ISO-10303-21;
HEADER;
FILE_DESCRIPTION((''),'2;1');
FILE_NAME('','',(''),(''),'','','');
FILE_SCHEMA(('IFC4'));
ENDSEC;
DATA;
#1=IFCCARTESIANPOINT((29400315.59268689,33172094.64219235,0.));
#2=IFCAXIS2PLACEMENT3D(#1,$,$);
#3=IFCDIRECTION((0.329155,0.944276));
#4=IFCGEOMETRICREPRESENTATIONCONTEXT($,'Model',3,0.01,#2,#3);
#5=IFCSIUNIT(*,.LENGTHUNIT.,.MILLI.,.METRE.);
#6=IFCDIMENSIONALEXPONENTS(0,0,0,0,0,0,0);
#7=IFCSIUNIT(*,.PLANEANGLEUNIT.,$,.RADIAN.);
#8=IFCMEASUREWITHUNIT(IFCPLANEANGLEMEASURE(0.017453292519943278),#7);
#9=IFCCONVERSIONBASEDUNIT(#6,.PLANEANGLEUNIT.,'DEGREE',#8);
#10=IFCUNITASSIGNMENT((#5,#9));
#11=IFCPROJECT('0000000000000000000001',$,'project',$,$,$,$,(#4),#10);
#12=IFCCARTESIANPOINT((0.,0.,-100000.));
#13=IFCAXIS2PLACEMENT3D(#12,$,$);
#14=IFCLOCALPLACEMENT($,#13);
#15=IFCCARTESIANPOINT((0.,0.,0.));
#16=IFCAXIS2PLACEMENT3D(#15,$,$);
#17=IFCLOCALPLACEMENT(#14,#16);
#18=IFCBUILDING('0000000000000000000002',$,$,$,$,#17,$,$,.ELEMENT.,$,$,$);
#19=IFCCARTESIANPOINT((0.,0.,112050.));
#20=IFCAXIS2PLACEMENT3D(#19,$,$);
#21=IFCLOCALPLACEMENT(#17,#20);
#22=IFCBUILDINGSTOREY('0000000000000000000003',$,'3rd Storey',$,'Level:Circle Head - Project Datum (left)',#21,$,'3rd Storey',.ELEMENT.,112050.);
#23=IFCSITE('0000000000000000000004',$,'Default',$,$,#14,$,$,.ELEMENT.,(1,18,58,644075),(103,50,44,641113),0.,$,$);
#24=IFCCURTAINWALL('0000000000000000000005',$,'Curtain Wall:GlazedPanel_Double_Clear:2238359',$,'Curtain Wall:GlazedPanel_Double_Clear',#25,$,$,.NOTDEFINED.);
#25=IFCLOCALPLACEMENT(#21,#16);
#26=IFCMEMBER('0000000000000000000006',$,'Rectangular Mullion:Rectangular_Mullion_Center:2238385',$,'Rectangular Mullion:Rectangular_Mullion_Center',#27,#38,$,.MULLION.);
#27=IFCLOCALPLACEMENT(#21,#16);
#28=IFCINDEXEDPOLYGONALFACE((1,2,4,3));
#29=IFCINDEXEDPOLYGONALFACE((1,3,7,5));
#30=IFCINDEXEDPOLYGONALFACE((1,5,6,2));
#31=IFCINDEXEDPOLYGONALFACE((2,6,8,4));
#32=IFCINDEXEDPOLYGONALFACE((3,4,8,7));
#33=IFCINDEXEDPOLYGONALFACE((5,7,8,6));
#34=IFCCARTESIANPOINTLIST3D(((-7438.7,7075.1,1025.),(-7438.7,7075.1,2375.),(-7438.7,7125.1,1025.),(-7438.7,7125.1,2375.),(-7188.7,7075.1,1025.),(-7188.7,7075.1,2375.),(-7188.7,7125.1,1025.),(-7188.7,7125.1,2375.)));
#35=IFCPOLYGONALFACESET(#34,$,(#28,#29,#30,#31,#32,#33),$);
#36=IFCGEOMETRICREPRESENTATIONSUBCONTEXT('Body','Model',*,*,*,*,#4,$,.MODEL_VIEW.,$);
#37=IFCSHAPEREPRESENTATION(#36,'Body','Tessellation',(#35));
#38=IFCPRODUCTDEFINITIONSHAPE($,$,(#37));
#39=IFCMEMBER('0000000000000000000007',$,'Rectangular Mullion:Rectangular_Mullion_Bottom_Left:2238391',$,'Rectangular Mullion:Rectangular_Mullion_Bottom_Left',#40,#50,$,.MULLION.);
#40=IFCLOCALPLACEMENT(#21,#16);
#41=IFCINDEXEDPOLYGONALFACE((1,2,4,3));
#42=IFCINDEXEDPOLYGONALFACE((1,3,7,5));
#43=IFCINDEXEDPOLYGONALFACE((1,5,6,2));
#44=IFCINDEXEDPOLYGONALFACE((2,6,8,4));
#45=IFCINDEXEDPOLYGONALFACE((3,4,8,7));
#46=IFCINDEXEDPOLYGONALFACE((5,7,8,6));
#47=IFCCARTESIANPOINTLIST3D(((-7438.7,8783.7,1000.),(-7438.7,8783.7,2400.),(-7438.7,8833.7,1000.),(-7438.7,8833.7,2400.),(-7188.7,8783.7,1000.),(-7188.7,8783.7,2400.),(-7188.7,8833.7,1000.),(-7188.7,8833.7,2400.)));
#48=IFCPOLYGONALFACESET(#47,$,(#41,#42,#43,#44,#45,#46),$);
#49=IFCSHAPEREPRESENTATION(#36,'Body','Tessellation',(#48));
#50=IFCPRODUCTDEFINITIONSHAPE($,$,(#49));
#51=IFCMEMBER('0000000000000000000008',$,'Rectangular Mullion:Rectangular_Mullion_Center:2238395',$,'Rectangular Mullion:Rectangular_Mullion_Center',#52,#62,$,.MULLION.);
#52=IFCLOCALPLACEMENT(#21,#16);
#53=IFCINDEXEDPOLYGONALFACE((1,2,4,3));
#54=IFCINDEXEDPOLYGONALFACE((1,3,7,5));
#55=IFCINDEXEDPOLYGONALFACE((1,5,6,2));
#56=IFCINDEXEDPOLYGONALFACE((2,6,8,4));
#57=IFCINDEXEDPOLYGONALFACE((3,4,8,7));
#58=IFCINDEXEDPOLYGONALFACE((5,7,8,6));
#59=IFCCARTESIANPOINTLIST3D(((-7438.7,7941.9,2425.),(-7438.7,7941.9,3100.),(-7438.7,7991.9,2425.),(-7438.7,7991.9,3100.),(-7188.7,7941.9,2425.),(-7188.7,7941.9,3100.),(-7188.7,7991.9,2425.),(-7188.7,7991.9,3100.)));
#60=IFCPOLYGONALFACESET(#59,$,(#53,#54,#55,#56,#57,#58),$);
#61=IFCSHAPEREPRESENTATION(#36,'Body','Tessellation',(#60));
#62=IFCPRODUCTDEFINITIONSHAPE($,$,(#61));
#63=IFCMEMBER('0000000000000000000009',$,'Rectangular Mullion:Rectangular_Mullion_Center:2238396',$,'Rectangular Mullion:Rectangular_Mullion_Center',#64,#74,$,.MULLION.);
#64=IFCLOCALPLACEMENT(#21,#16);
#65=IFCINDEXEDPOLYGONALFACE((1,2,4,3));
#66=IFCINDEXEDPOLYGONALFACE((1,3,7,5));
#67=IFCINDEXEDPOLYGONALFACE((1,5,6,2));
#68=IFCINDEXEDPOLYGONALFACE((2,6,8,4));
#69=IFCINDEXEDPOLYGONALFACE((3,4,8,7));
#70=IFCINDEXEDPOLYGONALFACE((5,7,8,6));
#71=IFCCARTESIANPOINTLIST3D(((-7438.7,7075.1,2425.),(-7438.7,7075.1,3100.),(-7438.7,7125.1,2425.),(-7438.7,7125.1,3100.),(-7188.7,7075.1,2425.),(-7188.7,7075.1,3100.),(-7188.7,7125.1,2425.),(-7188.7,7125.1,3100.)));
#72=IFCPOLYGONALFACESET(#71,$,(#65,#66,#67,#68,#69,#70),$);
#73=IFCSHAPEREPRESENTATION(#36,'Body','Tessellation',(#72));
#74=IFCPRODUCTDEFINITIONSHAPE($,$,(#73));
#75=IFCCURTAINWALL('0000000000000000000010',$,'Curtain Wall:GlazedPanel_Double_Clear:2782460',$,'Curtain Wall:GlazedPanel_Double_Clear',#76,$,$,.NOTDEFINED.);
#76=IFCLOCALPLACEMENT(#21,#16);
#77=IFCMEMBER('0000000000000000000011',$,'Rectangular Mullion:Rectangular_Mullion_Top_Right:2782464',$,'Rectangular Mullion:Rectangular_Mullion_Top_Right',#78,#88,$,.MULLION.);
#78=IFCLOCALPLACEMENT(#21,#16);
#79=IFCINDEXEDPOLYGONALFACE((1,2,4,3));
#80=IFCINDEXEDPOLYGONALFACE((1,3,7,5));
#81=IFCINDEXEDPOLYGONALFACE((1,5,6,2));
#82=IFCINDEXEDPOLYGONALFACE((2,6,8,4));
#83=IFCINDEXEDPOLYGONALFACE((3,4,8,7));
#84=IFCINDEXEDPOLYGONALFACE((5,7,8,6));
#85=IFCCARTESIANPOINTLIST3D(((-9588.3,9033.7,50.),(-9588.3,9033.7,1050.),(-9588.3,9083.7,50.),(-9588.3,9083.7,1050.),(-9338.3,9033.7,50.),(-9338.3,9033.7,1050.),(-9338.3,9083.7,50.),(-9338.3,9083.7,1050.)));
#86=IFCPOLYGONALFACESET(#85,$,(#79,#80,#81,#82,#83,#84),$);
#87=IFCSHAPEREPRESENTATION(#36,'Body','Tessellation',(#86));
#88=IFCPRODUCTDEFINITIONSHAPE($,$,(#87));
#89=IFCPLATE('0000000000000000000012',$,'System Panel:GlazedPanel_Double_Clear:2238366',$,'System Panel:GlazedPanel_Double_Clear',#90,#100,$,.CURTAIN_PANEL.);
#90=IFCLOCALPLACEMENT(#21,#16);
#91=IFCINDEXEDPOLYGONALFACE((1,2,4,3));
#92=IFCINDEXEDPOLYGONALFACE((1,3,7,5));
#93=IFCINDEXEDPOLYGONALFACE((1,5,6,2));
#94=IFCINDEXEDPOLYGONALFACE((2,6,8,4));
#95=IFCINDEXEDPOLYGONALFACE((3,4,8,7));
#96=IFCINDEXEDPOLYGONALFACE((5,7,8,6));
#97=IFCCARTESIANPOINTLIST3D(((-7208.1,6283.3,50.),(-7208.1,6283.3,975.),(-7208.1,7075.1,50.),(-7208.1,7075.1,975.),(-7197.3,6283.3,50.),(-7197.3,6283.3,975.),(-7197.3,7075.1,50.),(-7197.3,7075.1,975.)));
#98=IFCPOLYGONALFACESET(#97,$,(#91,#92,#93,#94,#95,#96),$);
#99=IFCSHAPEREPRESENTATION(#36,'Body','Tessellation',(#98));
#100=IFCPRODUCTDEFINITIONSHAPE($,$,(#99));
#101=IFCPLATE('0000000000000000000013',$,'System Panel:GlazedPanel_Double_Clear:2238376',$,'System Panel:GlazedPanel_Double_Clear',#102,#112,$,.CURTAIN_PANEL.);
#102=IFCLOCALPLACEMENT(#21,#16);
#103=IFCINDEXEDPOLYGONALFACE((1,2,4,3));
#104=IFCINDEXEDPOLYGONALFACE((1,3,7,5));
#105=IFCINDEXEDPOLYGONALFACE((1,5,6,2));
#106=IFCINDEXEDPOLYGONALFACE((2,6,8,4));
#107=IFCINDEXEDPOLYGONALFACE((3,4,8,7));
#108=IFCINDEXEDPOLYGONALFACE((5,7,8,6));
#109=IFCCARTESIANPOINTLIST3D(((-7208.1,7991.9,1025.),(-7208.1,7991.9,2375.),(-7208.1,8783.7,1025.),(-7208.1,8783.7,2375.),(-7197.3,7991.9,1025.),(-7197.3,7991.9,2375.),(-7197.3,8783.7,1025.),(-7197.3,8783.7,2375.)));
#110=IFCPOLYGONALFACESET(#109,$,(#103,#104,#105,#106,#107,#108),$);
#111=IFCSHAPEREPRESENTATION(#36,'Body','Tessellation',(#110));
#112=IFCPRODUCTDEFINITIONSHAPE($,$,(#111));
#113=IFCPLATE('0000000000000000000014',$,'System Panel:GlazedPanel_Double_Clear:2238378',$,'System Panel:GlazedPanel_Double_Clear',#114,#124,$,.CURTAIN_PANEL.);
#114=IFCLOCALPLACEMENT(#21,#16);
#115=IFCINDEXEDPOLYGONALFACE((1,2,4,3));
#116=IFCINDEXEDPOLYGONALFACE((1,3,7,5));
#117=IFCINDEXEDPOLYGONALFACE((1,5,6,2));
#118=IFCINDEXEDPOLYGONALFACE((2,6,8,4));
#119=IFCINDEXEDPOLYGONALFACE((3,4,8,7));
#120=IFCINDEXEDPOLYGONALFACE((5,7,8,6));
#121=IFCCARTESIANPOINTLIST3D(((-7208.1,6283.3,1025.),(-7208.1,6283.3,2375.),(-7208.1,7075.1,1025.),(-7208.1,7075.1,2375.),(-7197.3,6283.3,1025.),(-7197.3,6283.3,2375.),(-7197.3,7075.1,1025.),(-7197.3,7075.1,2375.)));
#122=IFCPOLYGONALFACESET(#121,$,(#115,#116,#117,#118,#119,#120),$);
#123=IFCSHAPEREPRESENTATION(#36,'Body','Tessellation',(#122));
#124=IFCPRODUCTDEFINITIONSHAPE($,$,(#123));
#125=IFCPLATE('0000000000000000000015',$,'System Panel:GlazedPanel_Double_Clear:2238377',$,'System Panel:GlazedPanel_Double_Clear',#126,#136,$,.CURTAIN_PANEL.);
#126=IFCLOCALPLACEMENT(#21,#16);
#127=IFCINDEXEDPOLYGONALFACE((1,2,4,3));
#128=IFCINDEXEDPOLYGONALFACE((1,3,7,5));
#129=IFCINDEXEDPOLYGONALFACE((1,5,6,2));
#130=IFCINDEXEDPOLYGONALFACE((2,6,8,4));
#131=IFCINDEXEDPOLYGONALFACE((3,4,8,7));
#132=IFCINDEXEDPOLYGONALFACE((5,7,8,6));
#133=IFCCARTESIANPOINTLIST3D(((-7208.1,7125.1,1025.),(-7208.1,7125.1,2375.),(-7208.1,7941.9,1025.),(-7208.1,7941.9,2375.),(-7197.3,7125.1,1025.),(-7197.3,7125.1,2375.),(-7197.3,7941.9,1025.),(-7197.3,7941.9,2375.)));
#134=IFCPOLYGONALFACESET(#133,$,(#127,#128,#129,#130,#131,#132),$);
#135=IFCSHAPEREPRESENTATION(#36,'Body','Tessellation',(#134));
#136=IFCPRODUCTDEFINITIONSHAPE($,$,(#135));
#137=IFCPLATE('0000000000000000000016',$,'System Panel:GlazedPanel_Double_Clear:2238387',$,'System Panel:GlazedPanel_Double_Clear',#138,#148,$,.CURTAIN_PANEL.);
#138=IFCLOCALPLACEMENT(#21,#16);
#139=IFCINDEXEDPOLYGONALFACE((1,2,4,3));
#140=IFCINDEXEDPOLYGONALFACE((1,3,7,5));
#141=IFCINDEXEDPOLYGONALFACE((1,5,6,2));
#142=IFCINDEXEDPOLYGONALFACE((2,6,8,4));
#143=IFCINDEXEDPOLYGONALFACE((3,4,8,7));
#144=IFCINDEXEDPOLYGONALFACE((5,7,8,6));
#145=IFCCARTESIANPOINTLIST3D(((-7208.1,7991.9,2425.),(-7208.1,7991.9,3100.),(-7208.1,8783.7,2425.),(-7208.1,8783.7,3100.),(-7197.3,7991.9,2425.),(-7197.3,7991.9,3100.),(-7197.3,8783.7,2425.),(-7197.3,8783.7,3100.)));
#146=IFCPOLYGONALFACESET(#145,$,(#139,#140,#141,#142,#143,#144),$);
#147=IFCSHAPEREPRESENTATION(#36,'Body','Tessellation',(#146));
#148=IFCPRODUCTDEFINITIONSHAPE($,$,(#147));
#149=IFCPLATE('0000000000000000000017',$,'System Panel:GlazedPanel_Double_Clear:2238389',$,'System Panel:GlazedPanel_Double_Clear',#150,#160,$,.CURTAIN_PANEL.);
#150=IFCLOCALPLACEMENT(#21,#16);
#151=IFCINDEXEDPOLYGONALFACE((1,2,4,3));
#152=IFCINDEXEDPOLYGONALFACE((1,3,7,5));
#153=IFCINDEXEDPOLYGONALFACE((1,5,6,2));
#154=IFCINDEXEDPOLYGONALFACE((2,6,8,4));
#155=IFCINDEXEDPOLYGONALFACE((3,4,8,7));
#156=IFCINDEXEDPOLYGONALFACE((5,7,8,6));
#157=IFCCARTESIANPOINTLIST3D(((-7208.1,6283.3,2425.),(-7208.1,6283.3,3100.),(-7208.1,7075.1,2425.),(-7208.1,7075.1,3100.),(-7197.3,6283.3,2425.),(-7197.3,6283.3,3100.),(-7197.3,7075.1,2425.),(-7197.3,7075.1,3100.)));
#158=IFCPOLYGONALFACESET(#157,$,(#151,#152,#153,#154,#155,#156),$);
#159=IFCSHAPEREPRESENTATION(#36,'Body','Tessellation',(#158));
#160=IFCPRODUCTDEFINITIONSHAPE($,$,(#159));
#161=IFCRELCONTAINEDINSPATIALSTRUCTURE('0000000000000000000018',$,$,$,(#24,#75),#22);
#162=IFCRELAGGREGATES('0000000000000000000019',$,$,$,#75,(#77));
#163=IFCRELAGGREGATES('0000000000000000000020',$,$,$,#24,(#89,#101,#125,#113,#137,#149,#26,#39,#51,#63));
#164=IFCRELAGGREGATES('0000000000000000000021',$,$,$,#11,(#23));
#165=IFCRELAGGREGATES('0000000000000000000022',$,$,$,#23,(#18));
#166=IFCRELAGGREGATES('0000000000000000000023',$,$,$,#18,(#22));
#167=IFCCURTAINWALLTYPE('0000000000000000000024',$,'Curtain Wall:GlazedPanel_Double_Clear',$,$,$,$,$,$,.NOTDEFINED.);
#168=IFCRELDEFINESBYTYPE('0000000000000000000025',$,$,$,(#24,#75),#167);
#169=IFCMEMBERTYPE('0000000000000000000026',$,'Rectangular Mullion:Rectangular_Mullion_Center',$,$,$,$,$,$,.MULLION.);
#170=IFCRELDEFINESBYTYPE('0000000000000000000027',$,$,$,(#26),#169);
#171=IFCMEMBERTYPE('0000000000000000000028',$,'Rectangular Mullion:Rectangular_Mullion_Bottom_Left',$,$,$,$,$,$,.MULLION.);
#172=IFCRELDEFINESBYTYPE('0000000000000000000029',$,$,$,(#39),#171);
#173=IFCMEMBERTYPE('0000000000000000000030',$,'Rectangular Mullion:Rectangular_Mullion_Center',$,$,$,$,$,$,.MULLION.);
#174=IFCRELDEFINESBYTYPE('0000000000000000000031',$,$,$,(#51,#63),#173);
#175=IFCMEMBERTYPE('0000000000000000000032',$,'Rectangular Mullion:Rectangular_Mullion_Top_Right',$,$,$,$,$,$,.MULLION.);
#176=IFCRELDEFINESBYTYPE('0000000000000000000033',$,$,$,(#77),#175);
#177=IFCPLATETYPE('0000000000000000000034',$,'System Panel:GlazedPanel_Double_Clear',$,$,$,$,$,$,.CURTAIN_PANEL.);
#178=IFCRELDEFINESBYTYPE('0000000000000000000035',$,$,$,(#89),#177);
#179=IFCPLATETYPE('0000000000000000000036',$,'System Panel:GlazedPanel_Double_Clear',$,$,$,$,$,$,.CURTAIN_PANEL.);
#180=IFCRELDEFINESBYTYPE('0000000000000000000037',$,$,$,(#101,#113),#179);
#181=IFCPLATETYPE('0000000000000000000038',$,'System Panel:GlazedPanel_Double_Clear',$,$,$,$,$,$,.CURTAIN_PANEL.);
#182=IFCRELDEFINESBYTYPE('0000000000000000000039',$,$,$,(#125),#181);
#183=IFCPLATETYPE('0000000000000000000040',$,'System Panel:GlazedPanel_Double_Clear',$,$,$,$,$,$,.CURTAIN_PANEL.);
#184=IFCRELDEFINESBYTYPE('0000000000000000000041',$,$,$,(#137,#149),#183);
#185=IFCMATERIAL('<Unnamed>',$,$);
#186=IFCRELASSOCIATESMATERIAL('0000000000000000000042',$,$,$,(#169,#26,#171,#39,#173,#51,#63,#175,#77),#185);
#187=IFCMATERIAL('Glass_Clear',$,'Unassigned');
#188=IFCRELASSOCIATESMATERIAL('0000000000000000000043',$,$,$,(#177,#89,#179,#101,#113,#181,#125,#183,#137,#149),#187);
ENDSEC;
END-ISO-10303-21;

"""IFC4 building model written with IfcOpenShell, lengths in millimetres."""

from ifc_helpers import new_model, entity, si_unit, converted_unit, direction, frame, origin, place, context, subcontext, project, spatial, indexed_curve, outline, extrude, source, transform, mapped, material, type_object, type_shapes, element, aggregate, save


model = new_model("IFC4")

# Units and contexts
model_context = context("Model", 3, precision=0.01, world=frame((29400315.59268689, 33172094.64219235, 0.0)), true_north=direction((0.329155, 0.944276)))
body_context = subcontext(model_context, "Body", "Model", "MODEL_VIEW")
ifc_project = project(units=[si_unit("LENGTHUNIT", "METRE", prefix="MILLI"), converted_unit("PLANEANGLEUNIT", "DEGREE", entity("IfcPlaneAngleMeasure", 0.017453292519943278), si_unit("PLANEANGLEUNIT", "RADIAN"), dimensions=[0, 0, 0, 0, 0, 0, 0])], contexts=[model_context])

# Site, building, storey
site_placement = place(None, frame((0.0, 0.0, -100000.0)))
site = spatial("IfcSite", under=ifc_project, at=site_placement, Name="Default", CompositionType="ELEMENT", RefLatitude=(1, 18, 58, 644075), RefLongitude=(103, 50, 44, 641113), RefElevation=0.0)
building_placement = place(site_placement, origin())
building = spatial("IfcBuilding", under=site, at=building_placement, CompositionType="ELEMENT")
storey_placement = place(building_placement, frame((0.0, 0.0, 112050.0)))
storey = spatial("IfcBuildingStorey", under=building, at=storey_placement, Name="3rd Storey", ObjectType="Level:Circle Head - Project Datum (left)", LongName="3rd Storey", CompositionType="ELEMENT", Elevation=112050.0)

# Curtain wall, members
curtain_wall_type = type_object("IfcCurtainWallType", Name="Curtain Wall:GlazedPanel_Double_Clear", PredefinedType="NOTDEFINED")
curtain_wall_1_placement = place(storey_placement, frame((0.0, 0.0, -112050.0)))
curtain_wall_1 = element("IfcCurtainWall", 1, at=curtain_wall_1_placement, inside=storey, type_object=curtain_wall_type, Name="Curtain Wall:GlazedPanel_Double_Clear:2238359", ObjectType="Curtain Wall:GlazedPanel_Double_Clear", PredefinedType="NOTDEFINED")
ifc_material_1 = material(Name="<Unnamed>")
member_type_1 = type_object("IfcMemberType", Name="Rectangular Mullion:Rectangular_Mullion_Center", PredefinedType="MULLION", material=ifc_material_1)
shared_shape_1 = source(origin(), body_context, "Body", "SweptSolid", [
    extrude(outline(indexed_curve([(-25.0, -125.0), (25.0, -125.0), (25.0, 125.0), (-25.0, 125.0), (-25.0, -125.0)], self_intersect=False)), frame((0.0, 0.0, -1350.0), z_axis=(0.0, 0.0, 1.0), x_axis=(-1.0, 0.0, 0.0)), (0.0, 0.0, 1.0), 1350.0),
])
type_shapes(member_type_1, [shared_shape_1])
member_1_placement = place(curtain_wall_1_placement, frame((-7313.7, 7100.1, 113075.0), z_axis=(0.0, 0.0, -1.0), x_axis=(0.0, -1.0, 0.0)))
member_1 = element("IfcMember", 2, at=member_1_placement, type_object=member_type_1, material=ifc_material_1, Name="Rectangular Mullion:Rectangular_Mullion_Center:2238385", ObjectType="Rectangular Mullion:Rectangular_Mullion_Center", PredefinedType="MULLION", context=body_context, shape_type="MappedRepresentation", body=[
    mapped(shared_shape_1, transform((0.0, 0.0, 0.0), scale=1.0)),
])
member_type_2 = type_object("IfcMemberType", Name="Rectangular Mullion:Rectangular_Mullion_Bottom_Left", PredefinedType="MULLION", material=ifc_material_1)
shared_shape_2 = source(origin(), body_context, "Body", "SweptSolid", [
    extrude(outline(indexed_curve([(-25.0, -125.0), (25.0, -125.0), (25.0, 125.0), (-25.0, 125.0), (-25.0, -125.0)], self_intersect=False)), frame((-25.0, 0.0, -1400.0), z_axis=(0.0, 0.0, 1.0), x_axis=(-1.0, 0.0, 0.0)), (0.0, 0.0, 1.0), 1400.0),
])
type_shapes(member_type_2, [shared_shape_2])
member_2_placement = place(curtain_wall_1_placement, frame((-7313.7, 8833.7, 114450.0), z_axis=(0.0, 0.0, 1.0), x_axis=(0.0, 1.0, 0.0)))
member_2 = element("IfcMember", 3, at=member_2_placement, type_object=member_type_2, material=ifc_material_1, Name="Rectangular Mullion:Rectangular_Mullion_Bottom_Left:2238391", ObjectType="Rectangular Mullion:Rectangular_Mullion_Bottom_Left", PredefinedType="MULLION", context=body_context, shape_type="MappedRepresentation", body=[
    mapped(shared_shape_2, transform((0.0, 0.0, 0.0), scale=1.0)),
])
member_type_3 = type_object("IfcMemberType", Name="Rectangular Mullion:Rectangular_Mullion_Center", PredefinedType="MULLION", material=ifc_material_1)
shared_shape_3 = source(origin(), body_context, "Body", "SweptSolid", [
    extrude(outline(indexed_curve([(-25.0, -125.0), (25.0, -125.0), (25.0, 125.0), (-25.0, 125.0), (-25.0, -125.0)], self_intersect=False)), frame((0.0, 0.0, -675.0), z_axis=(0.0, 0.0, 1.0), x_axis=(-1.0, 0.0, 0.0)), (0.0, 0.0, 1.0), 675.0),
])
type_shapes(member_type_3, [shared_shape_3])
member_3_placement = place(curtain_wall_1_placement, frame((-7313.7, 7966.9, 114475.0), z_axis=(0.0, 0.0, -1.0), x_axis=(0.0, -1.0, 0.0)))
member_3 = element("IfcMember", 4, at=member_3_placement, type_object=member_type_3, material=ifc_material_1, Name="Rectangular Mullion:Rectangular_Mullion_Center:2238395", ObjectType="Rectangular Mullion:Rectangular_Mullion_Center", PredefinedType="MULLION", context=body_context, shape_type="MappedRepresentation", body=[
    mapped(shared_shape_3, transform((0.0, 0.0, 0.0), scale=1.0)),
])
member_4_placement = place(curtain_wall_1_placement, frame((-7313.7, 7100.1, 114475.0), z_axis=(0.0, 0.0, -1.0), x_axis=(0.0, -1.0, 0.0)))
member_4 = element("IfcMember", 5, at=member_4_placement, type_object=member_type_3, material=ifc_material_1, Name="Rectangular Mullion:Rectangular_Mullion_Center:2238396", ObjectType="Rectangular Mullion:Rectangular_Mullion_Center", PredefinedType="MULLION", context=body_context, shape_type="MappedRepresentation", body=[
    mapped(shared_shape_3, transform((0.0, 0.0, 0.0), scale=1.0)),
])

# Curtain wall, member
curtain_wall_2_placement = place(storey_placement, frame((0.0, 0.0, -112050.0)))
curtain_wall_2 = element("IfcCurtainWall", 6, at=curtain_wall_2_placement, inside=storey, type_object=curtain_wall_type, Name="Curtain Wall:GlazedPanel_Double_Clear:2782460", ObjectType="Curtain Wall:GlazedPanel_Double_Clear", PredefinedType="NOTDEFINED")
member_type_4 = type_object("IfcMemberType", Name="Rectangular Mullion:Rectangular_Mullion_Top_Right", PredefinedType="MULLION", material=ifc_material_1)
shared_shape_4 = source(origin(), body_context, "Body", "SweptSolid", [
    extrude(outline(indexed_curve([(-25.0, -125.0), (25.0, -125.0), (25.0, 125.0), (-25.0, 125.0), (-25.0, -125.0)], self_intersect=False)), frame((-25.0, 0.0, -1000.0), z_axis=(0.0, 0.0, 1.0), x_axis=(-1.0, 0.0, 0.0)), (0.0, 0.0, 1.0), 1000.0),
])
type_shapes(member_type_4, [shared_shape_4])
member_5_placement = place(curtain_wall_2_placement, frame((-9463.3, 9033.7, 112100.0), z_axis=(0.0, 0.0, -1.0), x_axis=(0.0, -1.0, 0.0)))
member_5 = element("IfcMember", 7, at=member_5_placement, type_object=member_type_4, material=ifc_material_1, Name="Rectangular Mullion:Rectangular_Mullion_Top_Right:2782464", ObjectType="Rectangular Mullion:Rectangular_Mullion_Top_Right", PredefinedType="MULLION", context=body_context, shape_type="MappedRepresentation", body=[
    mapped(shared_shape_4, transform((0.0, 0.0, 0.0), scale=1.0)),
])
aggregate(curtain_wall_2, [member_5])

# Plates
ifc_material_2 = material(Name="Glass_Clear", Category="Unassigned")
plate_type_1 = type_object("IfcPlateType", Name="System Panel:GlazedPanel_Double_Clear", PredefinedType="CURTAIN_PANEL", material=ifc_material_2)
shared_shape_5 = source(origin(), body_context, "Body", "SweptSolid", [
    extrude(outline(indexed_curve([(-5.4, -395.9), (5.4, -395.9), (5.4, 395.9), (-5.4, 395.9), (-5.4, -395.9)], self_intersect=False)), frame((0.0, 111.0, 0.0), z_axis=(0.0, 0.0, 1.0), x_axis=(0.0, 1.0, 0.0)), (0.0, 0.0, 1.0), 925.0),
])
type_shapes(plate_type_1, [shared_shape_5])
plate_1_placement = place(curtain_wall_1_placement, frame((-7313.7, 6679.2, 112100.0), z_axis=(0.0, 0.0, 1.0), x_axis=(0.0, -1.0, 0.0)))
plate_1 = element("IfcPlate", 8, at=plate_1_placement, type_object=plate_type_1, material=ifc_material_2, Name="System Panel:GlazedPanel_Double_Clear:2238366", ObjectType="System Panel:GlazedPanel_Double_Clear", PredefinedType="CURTAIN_PANEL", context=body_context, shape_type="MappedRepresentation", body=[
    mapped(shared_shape_5, transform((0.0, 0.0, 0.0), scale=1.0)),
])
plate_type_2 = type_object("IfcPlateType", Name="System Panel:GlazedPanel_Double_Clear", PredefinedType="CURTAIN_PANEL", material=ifc_material_2)
shared_shape_6 = source(origin(), body_context, "Body", "SweptSolid", [
    extrude(outline(indexed_curve([(-5.4, -395.9), (5.4, -395.9), (5.4, 395.9), (-5.4, 395.9), (-5.4, -395.9)], self_intersect=False)), frame((0.0, 111.0, 0.0), z_axis=(0.0, 0.0, 1.0), x_axis=(0.0, 1.0, 0.0)), (0.0, 0.0, 1.0), 1350.0),
])
type_shapes(plate_type_2, [shared_shape_6])
plate_2_placement = place(curtain_wall_1_placement, frame((-7313.7, 8387.8, 113075.0), z_axis=(0.0, 0.0, 1.0), x_axis=(0.0, -1.0, 0.0)))
plate_2 = element("IfcPlate", 9, at=plate_2_placement, type_object=plate_type_2, material=ifc_material_2, Name="System Panel:GlazedPanel_Double_Clear:2238376", ObjectType="System Panel:GlazedPanel_Double_Clear", PredefinedType="CURTAIN_PANEL", context=body_context, shape_type="MappedRepresentation", body=[
    mapped(shared_shape_6, transform((0.0, 0.0, 0.0), scale=1.0)),
])
plate_3_placement = place(curtain_wall_1_placement, frame((-7313.7, 6679.2, 113075.0), z_axis=(0.0, 0.0, 1.0), x_axis=(0.0, -1.0, 0.0)))
plate_3 = element("IfcPlate", 10, at=plate_3_placement, type_object=plate_type_2, material=ifc_material_2, Name="System Panel:GlazedPanel_Double_Clear:2238378", ObjectType="System Panel:GlazedPanel_Double_Clear", PredefinedType="CURTAIN_PANEL", context=body_context, shape_type="MappedRepresentation", body=[
    mapped(shared_shape_6, transform((0.0, 0.0, 0.0), scale=1.0)),
])
plate_type_3 = type_object("IfcPlateType", Name="System Panel:GlazedPanel_Double_Clear", PredefinedType="CURTAIN_PANEL", material=ifc_material_2)
shared_shape_7 = source(origin(), body_context, "Body", "SweptSolid", [
    extrude(outline(indexed_curve([(-5.4, -408.4), (5.4, -408.4), (5.4, 408.4), (-5.4, 408.4), (-5.4, -408.4)], self_intersect=False)), frame((0.0, 111.0, 0.0), z_axis=(0.0, 0.0, 1.0), x_axis=(0.0, 1.0, 0.0)), (0.0, 0.0, 1.0), 1350.0),
])
type_shapes(plate_type_3, [shared_shape_7])
plate_4_placement = place(curtain_wall_1_placement, frame((-7313.7, 7533.5, 113075.0), z_axis=(0.0, 0.0, 1.0), x_axis=(0.0, -1.0, 0.0)))
plate_4 = element("IfcPlate", 11, at=plate_4_placement, type_object=plate_type_3, material=ifc_material_2, Name="System Panel:GlazedPanel_Double_Clear:2238377", ObjectType="System Panel:GlazedPanel_Double_Clear", PredefinedType="CURTAIN_PANEL", context=body_context, shape_type="MappedRepresentation", body=[
    mapped(shared_shape_7, transform((0.0, 0.0, 0.0), scale=1.0)),
])
plate_type_4 = type_object("IfcPlateType", Name="System Panel:GlazedPanel_Double_Clear", PredefinedType="CURTAIN_PANEL", material=ifc_material_2)
shared_shape_8 = source(origin(), body_context, "Body", "SweptSolid", [
    extrude(outline(indexed_curve([(-5.4, -395.9), (5.4, -395.9), (5.4, 395.9), (-5.4, 395.9), (-5.4, -395.9)], self_intersect=False)), frame((0.0, 111.0, 0.0), z_axis=(0.0, 0.0, 1.0), x_axis=(0.0, 1.0, 0.0)), (0.0, 0.0, 1.0), 675.0),
])
type_shapes(plate_type_4, [shared_shape_8])
plate_5_placement = place(curtain_wall_1_placement, frame((-7313.7, 8387.8, 114475.0), z_axis=(0.0, 0.0, 1.0), x_axis=(0.0, -1.0, 0.0)))
plate_5 = element("IfcPlate", 12, at=plate_5_placement, type_object=plate_type_4, material=ifc_material_2, Name="System Panel:GlazedPanel_Double_Clear:2238387", ObjectType="System Panel:GlazedPanel_Double_Clear", PredefinedType="CURTAIN_PANEL", context=body_context, shape_type="MappedRepresentation", body=[
    mapped(shared_shape_8, transform((0.0, 0.0, 0.0), scale=1.0)),
])
plate_6_placement = place(curtain_wall_1_placement, frame((-7313.7, 6679.2, 114475.0), z_axis=(0.0, 0.0, 1.0), x_axis=(0.0, -1.0, 0.0)))
plate_6 = element("IfcPlate", 13, at=plate_6_placement, type_object=plate_type_4, material=ifc_material_2, Name="System Panel:GlazedPanel_Double_Clear:2238389", ObjectType="System Panel:GlazedPanel_Double_Clear", PredefinedType="CURTAIN_PANEL", context=body_context, shape_type="MappedRepresentation", body=[
    mapped(shared_shape_8, transform((0.0, 0.0, 0.0), scale=1.0)),
])
aggregate(curtain_wall_1, [plate_1, plate_2, plate_4, plate_3, plate_5, plate_6, member_1, member_2, member_3, member_4])

save(model, "model.ifc")
